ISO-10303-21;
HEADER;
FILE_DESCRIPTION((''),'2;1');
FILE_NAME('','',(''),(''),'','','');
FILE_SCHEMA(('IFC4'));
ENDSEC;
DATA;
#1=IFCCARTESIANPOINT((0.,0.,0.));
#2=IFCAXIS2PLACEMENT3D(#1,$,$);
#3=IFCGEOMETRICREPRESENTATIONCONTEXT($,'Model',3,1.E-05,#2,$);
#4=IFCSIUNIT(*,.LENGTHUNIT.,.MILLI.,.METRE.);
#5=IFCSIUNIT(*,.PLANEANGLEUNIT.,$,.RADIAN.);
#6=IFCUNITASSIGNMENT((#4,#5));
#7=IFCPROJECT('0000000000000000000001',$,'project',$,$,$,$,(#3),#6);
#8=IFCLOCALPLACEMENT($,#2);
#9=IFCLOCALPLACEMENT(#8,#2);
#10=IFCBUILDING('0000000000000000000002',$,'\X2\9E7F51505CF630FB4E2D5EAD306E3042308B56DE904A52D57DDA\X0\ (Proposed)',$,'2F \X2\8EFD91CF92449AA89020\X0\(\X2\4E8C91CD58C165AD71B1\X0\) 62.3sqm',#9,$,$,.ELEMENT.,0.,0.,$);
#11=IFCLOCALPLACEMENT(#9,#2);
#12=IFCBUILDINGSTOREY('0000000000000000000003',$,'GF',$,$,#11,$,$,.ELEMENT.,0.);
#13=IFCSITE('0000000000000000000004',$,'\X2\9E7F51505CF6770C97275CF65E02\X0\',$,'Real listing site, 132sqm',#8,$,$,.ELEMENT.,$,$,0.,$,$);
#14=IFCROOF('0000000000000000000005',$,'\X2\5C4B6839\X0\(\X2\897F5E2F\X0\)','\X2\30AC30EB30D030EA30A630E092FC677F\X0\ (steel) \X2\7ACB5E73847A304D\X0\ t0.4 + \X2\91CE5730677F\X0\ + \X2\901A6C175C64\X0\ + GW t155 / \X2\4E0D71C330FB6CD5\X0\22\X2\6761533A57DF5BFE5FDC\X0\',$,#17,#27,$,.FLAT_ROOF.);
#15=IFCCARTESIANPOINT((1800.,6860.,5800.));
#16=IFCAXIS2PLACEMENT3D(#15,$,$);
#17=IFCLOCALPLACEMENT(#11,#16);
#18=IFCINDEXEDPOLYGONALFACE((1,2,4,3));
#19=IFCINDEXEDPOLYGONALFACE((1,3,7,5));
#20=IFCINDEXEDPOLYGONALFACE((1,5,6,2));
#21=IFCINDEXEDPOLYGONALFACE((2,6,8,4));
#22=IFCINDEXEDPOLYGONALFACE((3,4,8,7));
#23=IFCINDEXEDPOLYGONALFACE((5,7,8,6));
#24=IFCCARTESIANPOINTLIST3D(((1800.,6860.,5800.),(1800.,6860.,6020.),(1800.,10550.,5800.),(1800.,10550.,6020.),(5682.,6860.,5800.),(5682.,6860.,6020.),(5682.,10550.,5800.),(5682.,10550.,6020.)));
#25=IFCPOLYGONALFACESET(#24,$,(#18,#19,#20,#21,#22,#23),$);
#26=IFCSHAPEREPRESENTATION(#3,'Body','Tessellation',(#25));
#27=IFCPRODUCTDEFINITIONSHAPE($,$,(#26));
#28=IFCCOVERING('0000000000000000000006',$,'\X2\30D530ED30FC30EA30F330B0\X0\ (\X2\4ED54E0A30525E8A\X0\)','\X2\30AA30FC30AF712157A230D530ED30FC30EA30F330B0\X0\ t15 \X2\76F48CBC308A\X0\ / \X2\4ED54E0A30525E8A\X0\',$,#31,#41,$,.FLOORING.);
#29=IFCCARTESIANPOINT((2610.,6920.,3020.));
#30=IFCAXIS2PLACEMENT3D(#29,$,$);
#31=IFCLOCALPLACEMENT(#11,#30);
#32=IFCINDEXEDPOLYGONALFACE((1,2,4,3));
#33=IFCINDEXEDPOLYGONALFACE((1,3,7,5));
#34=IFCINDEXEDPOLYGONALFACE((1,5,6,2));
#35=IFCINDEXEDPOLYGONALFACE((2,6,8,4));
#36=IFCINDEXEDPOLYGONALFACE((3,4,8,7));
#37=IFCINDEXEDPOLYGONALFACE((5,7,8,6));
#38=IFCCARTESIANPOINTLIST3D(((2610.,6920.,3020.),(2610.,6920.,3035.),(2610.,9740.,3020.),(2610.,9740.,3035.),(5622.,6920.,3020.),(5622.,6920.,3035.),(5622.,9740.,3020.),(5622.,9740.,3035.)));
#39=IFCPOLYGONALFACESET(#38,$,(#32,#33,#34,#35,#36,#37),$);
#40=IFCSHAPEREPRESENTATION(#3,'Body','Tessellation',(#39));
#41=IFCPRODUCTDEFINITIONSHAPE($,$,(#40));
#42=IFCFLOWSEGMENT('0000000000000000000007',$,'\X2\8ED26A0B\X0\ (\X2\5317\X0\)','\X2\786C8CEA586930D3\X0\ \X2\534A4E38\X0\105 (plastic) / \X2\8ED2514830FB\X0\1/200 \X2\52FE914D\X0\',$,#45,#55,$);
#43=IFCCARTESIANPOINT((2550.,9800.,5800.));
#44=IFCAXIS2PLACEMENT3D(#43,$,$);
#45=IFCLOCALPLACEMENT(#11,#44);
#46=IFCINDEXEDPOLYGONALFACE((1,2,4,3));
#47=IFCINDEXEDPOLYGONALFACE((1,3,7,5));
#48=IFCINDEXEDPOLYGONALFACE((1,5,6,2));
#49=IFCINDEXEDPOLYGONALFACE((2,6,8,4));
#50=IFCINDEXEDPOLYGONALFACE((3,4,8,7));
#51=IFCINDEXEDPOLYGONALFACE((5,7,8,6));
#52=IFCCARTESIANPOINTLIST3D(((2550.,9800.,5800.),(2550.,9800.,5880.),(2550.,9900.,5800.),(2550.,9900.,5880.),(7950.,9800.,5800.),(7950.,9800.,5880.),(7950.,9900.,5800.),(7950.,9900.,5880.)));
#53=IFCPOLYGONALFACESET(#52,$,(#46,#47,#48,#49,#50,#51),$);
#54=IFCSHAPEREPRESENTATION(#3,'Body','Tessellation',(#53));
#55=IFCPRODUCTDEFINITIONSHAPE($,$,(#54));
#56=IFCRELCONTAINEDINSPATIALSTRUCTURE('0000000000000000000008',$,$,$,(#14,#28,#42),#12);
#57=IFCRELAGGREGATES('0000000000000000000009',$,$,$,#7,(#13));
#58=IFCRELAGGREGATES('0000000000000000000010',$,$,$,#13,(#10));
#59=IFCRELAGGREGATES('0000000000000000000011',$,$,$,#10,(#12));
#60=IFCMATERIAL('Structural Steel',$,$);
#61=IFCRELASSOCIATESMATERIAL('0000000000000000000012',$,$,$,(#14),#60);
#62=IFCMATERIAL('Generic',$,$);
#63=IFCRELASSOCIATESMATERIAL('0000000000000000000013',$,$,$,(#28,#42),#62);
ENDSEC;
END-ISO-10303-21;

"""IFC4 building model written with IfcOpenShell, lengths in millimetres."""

from ifc_helpers import new_model, si_unit, frame, frame_2d, origin, place, context, project, spatial, rectangle, extrude, material, element, save


model = new_model("IFC4")

# Units and contexts
model_context = context("Model", 3, precision=1e-05, world=origin())
ifc_project = project(units=[si_unit("LENGTHUNIT", "METRE", prefix="MILLI"), si_unit("PLANEANGLEUNIT", "RADIAN")], contexts=[model_context])

# Site, building, storey
site_placement = place(None, origin())
site = spatial("IfcSite", under=ifc_project, at=site_placement, Name="鹿児島県霧島市", ObjectType="Real listing site, 132sqm", CompositionType="ELEMENT", RefElevation=0.0)
building_placement = place(site_placement, origin())
building = spatial("IfcBuilding", under=site, at=building_placement, Name="鹿児島・中庭のある回遊動線 (Proposed)", ObjectType="2F 軽量鉄骨造(二重壁断熱) 62.3sqm", CompositionType="ELEMENT", ElevationOfRefHeight=0.0, ElevationOfTerrain=0.0)
storey_placement = place(building_placement, origin())
storey = spatial("IfcBuildingStorey", under=building, at=storey_placement, Name="GF", CompositionType="ELEMENT", Elevation=0.0)

# Roof
ifc_material_1 = material(Name="Structural Steel")
for number, where, name in (
    (1, (1800.0, 6860.0, 5800.0), "屋根(西帯)"),
):
    element("IfcRoof", number, at=place(storey_placement, frame(where)), inside=storey, material=ifc_material_1, Name=name, Description="ガルバリウム鋼板 (steel) 立平葺き t0.4 + 野地板 + 通気層 + GW t155 / 不燃・法22条区域対応", PredefinedType="FLAT_ROOF", context=model_context, shape_type="SweptSolid", body=[
        extrude(rectangle(XDim=3882.0, YDim=3690.0, at=frame_2d((1941.0, 1845.0))), frame((1800.0, 6860.0, 5800.0)), (0.0, 0.0, 1.0), 220.0),
    ])

# Covering
ifc_material_2 = material(Name="Generic")
covering_placement = place(storey_placement, frame((2610.0, 6920.0, 3020.0)))
element("IfcCovering", 2, at=covering_placement, inside=storey, material=ifc_material_2, Name="フローリング (仕上げ床)", Description="オーク無垢フローリング t15 直貼り / 仕上げ床", PredefinedType="FLOORING", context=model_context, shape_type="SweptSolid", body=[
    extrude(rectangle(XDim=3012.0, YDim=2820.0, at=frame_2d((1506.0, 1410.0))), frame((2610.0, 6920.0, 3020.0)), (0.0, 0.0, 1.0), 15.0),
])

# Flow segment
flow_segment_placement = place(storey_placement, frame((2550.0, 9800.0, 5800.0)))
element("IfcFlowSegment", 3, at=flow_segment_placement, inside=storey, material=ifc_material_2, Name="軒樋 (北)", Description="硬質塩ビ 半丸105 (plastic) / 軒先・1/200 勾配", context=model_context, shape_type="SweptSolid", body=[
    extrude(rectangle(XDim=5400.0, YDim=100.0, at=frame_2d((2700.0, 50.0))), frame((2550.0, 9800.0, 5800.0)), (0.0, 0.0, 1.0), 80.0),
])

save(model, "model.ifc")
